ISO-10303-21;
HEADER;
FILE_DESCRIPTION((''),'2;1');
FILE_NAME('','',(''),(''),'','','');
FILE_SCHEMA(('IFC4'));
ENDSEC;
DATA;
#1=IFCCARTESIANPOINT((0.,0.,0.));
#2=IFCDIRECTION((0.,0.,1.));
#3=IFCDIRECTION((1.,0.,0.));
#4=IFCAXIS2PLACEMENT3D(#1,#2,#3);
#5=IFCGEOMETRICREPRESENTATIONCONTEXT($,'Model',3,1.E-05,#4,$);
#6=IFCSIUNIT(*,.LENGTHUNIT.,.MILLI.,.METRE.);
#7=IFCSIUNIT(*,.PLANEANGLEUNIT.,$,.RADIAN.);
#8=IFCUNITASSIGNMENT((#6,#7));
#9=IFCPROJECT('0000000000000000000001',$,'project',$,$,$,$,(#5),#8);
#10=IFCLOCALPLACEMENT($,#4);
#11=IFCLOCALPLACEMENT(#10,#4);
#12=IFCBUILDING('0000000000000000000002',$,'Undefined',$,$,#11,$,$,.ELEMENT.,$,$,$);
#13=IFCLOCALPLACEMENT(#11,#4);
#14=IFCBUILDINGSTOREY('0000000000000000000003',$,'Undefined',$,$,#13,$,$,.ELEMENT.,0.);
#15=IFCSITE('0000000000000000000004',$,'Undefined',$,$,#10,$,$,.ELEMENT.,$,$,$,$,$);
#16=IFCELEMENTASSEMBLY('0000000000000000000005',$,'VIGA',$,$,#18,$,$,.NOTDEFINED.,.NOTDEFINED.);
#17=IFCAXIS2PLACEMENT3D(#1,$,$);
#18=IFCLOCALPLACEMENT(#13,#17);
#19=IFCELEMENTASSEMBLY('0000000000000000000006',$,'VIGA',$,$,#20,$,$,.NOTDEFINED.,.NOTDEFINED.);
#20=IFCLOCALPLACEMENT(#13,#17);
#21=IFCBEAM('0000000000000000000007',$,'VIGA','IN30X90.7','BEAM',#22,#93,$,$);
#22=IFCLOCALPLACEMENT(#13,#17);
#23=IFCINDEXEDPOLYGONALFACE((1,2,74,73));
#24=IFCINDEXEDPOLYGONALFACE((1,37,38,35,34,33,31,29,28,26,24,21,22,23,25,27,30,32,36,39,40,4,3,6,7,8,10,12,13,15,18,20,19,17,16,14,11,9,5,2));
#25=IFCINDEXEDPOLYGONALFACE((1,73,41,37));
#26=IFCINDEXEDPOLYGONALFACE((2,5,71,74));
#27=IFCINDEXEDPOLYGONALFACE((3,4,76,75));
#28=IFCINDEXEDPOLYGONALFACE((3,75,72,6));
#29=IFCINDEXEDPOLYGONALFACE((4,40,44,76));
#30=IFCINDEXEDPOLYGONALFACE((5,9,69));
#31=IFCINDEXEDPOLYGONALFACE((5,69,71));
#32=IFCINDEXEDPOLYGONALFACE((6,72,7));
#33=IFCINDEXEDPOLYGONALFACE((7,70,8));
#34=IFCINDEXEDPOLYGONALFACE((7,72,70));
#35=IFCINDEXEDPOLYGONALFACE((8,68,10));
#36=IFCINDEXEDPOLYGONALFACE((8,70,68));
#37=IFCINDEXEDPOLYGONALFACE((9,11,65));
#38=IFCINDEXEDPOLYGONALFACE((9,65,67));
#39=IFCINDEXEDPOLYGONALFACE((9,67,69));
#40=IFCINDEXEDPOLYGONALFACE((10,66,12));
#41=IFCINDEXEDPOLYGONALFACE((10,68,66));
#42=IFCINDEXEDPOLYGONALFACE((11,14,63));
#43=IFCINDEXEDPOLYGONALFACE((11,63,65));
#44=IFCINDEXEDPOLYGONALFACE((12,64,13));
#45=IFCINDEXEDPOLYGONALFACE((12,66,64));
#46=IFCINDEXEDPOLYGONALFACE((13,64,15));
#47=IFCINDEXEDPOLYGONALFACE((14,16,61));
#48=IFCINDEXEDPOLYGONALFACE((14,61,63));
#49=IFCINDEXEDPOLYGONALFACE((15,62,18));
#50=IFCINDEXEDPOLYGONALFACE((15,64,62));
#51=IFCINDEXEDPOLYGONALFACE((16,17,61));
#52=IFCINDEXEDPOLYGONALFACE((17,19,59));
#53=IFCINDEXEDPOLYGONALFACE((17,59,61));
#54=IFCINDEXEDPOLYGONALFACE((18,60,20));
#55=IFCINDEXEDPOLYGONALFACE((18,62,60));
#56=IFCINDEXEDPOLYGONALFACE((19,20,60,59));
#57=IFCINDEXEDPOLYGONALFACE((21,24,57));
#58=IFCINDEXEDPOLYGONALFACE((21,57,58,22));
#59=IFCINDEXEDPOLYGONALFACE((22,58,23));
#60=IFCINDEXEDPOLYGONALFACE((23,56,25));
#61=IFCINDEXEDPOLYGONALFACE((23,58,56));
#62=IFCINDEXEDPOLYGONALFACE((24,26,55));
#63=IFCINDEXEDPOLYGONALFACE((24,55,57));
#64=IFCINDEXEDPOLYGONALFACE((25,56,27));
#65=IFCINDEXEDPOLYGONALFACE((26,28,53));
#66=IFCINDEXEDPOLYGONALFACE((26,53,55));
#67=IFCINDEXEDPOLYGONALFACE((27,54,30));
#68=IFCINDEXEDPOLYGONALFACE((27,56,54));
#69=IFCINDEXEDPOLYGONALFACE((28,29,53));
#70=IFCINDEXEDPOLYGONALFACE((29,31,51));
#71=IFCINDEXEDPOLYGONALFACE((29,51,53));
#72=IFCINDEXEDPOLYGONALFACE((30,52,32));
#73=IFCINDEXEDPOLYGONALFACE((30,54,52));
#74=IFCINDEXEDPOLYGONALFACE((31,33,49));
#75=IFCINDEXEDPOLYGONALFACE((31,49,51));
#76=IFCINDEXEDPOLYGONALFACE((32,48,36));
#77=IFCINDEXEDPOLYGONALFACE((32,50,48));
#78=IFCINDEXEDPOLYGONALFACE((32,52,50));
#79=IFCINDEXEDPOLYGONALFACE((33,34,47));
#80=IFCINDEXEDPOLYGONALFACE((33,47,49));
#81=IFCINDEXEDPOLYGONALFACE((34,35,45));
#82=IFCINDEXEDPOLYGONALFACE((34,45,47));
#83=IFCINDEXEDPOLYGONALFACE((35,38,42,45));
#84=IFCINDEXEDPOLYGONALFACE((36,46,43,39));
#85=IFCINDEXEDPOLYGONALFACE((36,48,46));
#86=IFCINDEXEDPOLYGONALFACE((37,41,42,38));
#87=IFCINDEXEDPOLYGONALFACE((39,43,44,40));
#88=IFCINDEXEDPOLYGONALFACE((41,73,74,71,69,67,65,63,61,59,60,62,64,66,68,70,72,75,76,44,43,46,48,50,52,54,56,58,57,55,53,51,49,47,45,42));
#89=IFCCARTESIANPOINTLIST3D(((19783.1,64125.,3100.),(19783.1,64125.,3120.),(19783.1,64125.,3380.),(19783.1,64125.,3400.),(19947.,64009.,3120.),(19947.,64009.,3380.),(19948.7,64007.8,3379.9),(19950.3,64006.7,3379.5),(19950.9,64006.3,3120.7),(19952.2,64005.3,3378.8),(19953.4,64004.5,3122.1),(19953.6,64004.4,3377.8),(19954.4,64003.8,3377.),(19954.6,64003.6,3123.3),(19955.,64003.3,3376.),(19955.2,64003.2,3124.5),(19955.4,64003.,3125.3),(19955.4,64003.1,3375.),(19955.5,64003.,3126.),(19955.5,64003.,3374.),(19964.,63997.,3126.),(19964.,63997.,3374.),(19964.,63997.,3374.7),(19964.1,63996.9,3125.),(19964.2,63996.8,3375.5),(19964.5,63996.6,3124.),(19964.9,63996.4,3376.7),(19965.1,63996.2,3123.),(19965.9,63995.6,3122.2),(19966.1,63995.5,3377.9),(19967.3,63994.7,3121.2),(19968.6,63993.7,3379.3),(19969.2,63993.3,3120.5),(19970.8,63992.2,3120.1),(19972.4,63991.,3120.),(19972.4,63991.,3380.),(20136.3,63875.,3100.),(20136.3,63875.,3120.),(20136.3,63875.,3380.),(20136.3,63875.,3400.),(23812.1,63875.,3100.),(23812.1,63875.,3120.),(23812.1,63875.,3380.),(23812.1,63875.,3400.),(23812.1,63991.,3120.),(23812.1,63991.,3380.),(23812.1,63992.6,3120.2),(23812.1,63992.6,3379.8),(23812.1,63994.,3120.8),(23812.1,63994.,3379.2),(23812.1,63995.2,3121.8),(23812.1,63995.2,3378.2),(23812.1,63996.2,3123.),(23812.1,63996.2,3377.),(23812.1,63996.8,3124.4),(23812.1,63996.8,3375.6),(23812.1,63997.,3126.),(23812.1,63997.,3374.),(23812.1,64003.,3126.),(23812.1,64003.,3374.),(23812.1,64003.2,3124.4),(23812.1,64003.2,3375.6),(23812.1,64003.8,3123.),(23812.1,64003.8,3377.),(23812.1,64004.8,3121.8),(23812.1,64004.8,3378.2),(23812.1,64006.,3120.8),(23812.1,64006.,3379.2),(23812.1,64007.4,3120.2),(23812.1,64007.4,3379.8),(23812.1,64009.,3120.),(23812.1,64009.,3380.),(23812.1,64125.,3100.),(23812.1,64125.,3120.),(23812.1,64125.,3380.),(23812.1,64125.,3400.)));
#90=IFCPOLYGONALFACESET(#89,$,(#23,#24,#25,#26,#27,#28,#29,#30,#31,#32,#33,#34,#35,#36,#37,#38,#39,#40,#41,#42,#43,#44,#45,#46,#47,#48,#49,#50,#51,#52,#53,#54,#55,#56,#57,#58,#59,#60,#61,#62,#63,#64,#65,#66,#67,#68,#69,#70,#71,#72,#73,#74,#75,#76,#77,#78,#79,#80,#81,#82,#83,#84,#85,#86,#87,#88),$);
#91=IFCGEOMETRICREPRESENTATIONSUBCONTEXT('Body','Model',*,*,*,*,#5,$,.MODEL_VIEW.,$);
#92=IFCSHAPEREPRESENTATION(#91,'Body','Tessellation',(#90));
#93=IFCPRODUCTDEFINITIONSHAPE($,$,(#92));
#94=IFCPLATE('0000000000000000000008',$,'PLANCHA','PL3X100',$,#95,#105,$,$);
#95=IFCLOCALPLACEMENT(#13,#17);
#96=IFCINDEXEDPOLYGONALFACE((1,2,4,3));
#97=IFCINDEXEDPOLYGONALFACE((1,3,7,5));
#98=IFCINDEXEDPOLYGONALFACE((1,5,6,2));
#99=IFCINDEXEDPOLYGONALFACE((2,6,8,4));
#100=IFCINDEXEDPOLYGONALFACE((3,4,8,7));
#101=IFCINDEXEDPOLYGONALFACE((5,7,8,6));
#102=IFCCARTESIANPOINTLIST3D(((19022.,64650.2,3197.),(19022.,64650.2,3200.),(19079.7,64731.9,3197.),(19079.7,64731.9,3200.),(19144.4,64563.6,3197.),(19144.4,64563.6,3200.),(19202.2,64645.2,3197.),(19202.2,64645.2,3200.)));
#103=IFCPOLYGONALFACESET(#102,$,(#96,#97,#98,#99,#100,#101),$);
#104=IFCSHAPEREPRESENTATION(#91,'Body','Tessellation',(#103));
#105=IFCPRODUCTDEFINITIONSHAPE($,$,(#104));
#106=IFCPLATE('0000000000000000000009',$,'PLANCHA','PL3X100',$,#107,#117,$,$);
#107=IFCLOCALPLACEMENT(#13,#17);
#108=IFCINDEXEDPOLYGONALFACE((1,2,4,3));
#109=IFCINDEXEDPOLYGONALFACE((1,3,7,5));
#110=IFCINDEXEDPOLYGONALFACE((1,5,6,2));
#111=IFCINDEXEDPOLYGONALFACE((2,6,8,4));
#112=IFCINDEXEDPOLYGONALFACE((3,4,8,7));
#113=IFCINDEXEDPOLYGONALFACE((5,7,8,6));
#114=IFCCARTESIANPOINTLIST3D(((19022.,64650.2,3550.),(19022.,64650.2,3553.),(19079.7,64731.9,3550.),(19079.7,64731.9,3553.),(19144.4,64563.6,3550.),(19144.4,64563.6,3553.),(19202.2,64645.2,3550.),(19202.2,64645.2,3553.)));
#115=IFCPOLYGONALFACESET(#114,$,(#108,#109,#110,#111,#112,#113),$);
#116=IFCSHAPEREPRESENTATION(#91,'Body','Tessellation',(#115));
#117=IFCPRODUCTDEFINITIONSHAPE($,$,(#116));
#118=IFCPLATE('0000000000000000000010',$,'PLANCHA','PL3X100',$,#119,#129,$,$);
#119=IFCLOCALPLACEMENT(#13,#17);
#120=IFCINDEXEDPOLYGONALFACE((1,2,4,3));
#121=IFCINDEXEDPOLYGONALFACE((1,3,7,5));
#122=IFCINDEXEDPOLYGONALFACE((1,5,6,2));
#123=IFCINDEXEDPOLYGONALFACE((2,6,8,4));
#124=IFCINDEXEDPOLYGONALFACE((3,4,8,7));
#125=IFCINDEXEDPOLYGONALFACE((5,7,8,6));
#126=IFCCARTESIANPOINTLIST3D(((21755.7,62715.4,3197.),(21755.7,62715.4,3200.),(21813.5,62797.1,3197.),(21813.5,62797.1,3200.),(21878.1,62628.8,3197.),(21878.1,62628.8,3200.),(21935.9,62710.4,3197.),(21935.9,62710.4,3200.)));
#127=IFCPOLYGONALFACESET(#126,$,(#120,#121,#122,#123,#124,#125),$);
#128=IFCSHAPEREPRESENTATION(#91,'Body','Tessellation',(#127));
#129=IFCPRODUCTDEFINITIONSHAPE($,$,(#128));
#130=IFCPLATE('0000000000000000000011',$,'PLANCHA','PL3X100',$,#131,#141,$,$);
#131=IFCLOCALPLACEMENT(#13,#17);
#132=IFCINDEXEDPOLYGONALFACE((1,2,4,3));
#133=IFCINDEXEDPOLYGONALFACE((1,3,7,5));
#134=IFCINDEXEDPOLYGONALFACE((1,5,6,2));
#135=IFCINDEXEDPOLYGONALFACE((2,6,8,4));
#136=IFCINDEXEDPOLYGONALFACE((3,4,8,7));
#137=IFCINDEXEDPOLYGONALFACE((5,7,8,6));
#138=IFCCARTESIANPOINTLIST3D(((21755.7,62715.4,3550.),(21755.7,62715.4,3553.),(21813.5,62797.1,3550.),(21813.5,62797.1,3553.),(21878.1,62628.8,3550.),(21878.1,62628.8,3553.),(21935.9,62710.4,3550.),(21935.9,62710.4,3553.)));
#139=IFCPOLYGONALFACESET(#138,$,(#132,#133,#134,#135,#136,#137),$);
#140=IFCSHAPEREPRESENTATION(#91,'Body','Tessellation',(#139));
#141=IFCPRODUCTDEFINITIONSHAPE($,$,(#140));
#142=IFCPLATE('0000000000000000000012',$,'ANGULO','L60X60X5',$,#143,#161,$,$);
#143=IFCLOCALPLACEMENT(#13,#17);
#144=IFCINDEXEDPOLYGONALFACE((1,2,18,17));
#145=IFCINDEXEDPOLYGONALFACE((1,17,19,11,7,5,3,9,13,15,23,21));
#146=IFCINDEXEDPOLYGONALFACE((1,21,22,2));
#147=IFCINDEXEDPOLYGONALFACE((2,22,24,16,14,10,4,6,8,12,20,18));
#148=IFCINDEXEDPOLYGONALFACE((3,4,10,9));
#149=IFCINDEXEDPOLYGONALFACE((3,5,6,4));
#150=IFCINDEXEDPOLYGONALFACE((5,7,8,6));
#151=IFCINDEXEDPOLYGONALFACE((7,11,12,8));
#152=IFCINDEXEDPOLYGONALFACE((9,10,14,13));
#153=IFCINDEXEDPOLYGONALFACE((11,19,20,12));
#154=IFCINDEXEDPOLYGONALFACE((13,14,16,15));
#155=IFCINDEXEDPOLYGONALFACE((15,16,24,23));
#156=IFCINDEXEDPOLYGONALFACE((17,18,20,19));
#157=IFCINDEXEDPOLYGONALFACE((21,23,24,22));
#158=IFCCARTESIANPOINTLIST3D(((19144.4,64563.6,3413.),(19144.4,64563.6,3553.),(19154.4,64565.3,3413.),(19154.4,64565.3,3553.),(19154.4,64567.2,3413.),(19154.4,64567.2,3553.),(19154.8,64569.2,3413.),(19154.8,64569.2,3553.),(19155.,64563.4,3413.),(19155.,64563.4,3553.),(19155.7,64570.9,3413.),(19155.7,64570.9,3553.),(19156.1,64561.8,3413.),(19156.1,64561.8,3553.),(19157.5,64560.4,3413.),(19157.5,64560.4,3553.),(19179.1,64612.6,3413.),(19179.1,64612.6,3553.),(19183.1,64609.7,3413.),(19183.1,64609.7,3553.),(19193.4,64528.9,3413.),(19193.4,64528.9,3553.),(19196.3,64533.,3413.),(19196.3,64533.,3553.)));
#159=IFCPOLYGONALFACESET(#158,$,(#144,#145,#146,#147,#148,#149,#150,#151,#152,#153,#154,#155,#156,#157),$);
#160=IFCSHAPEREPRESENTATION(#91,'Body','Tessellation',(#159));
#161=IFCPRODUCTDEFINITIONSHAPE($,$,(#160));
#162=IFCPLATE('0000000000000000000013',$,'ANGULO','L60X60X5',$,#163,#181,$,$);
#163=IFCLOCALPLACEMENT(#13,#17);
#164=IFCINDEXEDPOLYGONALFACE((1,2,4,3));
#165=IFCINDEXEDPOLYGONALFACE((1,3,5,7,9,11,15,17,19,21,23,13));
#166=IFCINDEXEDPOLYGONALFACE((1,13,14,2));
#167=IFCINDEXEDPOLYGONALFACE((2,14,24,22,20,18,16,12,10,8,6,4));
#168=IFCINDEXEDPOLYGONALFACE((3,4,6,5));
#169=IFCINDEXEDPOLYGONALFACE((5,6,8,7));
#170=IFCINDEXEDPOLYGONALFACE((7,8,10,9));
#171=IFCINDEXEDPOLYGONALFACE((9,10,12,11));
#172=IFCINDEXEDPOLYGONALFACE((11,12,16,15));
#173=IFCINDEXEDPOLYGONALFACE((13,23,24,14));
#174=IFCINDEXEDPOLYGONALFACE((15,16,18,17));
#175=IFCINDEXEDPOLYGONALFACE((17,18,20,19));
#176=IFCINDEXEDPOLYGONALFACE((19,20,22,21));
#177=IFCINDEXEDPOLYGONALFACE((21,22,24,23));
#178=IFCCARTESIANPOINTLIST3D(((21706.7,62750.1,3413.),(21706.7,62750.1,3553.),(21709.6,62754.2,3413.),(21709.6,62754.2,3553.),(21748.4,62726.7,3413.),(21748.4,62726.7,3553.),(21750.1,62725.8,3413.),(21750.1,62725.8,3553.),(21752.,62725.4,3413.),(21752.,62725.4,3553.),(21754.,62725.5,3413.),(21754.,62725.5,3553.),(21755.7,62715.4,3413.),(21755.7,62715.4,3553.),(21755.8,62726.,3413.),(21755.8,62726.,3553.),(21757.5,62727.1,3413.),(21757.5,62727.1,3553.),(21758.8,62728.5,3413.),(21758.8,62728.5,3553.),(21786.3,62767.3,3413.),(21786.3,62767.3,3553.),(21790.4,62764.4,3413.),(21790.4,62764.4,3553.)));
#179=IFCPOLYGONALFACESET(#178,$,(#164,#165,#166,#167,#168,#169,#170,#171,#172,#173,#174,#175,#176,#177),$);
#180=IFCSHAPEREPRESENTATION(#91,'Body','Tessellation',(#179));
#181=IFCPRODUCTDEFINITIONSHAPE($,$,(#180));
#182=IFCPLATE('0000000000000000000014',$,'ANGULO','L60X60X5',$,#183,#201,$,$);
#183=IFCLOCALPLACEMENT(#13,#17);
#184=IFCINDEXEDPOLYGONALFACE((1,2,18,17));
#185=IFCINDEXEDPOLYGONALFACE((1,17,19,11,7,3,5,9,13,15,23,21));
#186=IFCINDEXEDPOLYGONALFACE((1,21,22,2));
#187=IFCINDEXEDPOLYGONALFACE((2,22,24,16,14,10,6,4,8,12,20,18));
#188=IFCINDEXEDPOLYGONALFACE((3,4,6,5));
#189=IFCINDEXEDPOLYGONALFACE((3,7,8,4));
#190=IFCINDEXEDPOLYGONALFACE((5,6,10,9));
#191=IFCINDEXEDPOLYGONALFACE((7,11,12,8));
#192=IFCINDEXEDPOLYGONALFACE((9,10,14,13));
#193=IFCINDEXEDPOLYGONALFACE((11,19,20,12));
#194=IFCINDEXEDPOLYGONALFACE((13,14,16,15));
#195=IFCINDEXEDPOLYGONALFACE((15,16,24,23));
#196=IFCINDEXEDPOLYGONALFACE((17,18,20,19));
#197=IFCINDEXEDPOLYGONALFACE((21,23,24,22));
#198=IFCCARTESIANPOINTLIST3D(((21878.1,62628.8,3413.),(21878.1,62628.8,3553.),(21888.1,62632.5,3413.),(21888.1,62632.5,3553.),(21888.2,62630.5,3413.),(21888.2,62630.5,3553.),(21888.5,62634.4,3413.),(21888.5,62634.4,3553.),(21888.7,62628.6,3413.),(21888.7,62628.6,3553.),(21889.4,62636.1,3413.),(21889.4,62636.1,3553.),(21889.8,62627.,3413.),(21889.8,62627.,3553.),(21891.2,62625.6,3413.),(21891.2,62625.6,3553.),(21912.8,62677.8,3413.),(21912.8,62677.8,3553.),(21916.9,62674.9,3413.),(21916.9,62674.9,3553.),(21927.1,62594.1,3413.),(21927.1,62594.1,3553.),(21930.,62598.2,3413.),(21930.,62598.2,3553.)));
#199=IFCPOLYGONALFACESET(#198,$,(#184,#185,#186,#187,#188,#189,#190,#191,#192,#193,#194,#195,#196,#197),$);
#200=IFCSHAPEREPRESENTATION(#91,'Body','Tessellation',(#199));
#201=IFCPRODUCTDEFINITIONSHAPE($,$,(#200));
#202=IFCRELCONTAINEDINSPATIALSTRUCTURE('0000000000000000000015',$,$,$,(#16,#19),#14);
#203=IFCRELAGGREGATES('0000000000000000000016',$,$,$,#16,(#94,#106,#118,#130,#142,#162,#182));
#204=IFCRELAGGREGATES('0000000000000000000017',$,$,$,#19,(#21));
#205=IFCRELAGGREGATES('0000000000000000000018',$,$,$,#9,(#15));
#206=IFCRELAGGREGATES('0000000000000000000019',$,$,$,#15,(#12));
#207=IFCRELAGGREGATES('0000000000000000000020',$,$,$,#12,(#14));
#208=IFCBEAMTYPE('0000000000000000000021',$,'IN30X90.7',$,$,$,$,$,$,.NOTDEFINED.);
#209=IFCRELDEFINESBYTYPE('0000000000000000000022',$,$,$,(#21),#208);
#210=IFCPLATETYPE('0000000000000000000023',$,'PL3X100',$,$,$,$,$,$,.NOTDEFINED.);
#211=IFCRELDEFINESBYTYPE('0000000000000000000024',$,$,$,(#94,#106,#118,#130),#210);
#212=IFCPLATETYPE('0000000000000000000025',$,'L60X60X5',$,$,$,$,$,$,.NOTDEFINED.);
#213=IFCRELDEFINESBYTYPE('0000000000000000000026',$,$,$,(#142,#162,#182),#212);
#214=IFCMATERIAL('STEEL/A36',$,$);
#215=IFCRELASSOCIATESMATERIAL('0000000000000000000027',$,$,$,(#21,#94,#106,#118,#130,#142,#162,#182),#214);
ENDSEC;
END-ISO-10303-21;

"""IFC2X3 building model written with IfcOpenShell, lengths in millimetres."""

from ifc_helpers import new_model, si_unit, frame, origin_with_axes, origin_2d_with_axis, place, context, subcontext, project, spatial, polyline, i_section, l_section, outline, extrude, clip, halfspace, material, type_object, element, aggregate, save


model = new_model("IFC2X3")

# Units and contexts
model_context = context("Model", 3, precision=1e-05, world=origin_with_axes())
body_context = subcontext(model_context, "Body", "Model", "MODEL_VIEW")
ifc_project = project(units=[si_unit("LENGTHUNIT", "METRE", prefix="MILLI"), si_unit("PLANEANGLEUNIT", "RADIAN")], contexts=[model_context])

# Site, building, storey
site_placement = place(None, origin_with_axes())
site = spatial("IfcSite", under=ifc_project, at=site_placement, Name="Undefined", CompositionType="ELEMENT")
building_placement = place(site_placement, origin_with_axes())
building = spatial("IfcBuilding", under=site, at=building_placement, Name="Undefined", CompositionType="ELEMENT")
storey_placement = place(building_placement, origin_with_axes())
storey = spatial("IfcBuildingStorey", under=building, at=storey_placement, Name="Undefined", CompositionType="ELEMENT", Elevation=0.0)

# Element assembly
assembly_1_placement = place(storey_placement, origin_with_axes())
assembly_1 = element("IfcElementAssembly", 1, at=assembly_1_placement, inside=storey, Name="VIGA", AssemblyPlace="NOTDEFINED", PredefinedType="NOTDEFINED")
ifc_material_1 = material(Name="STEEL/A36")

# Element assembly, beam
assembly_2_placement = place(storey_placement, origin_with_axes())
assembly_2 = element("IfcElementAssembly", 2, at=assembly_2_placement, inside=storey, Name="VIGA", AssemblyPlace="NOTDEFINED", PredefinedType="NOTDEFINED")
beam_type_1 = type_object("IfcBeamType", Name="IN30X90.7", PredefinedType="NOTDEFINED")
beam_1_placement = place(assembly_2_placement, frame((19924.1, 64000.0, 3250.0), z_axis=(0.0, 0.0, 1.0), x_axis=(1.0, 0.0, 0.0)))
beam_1 = element("IfcBeam", 3, at=beam_1_placement, type_object=beam_type_1, material=ifc_material_1, Name="VIGA", Description="IN30X90.7", ObjectType="BEAM", context=body_context, shape_type="Clipping", body=[
    clip(extrude(i_section(OverallWidth=250.0, OverallDepth=300.0, WebThickness=6.0, FlangeThickness=20.0, FilletRadius=6.0, at=origin_2d_with_axis()), frame((3888.0, 0.0, 0.0), z_axis=(-1.0, 0.0, 0.0), x_axis=(0.0, -1.0, 0.0)), (0.0, 0.0, 1.0), 4030.8), halfspace(frame((24.1, 8.2, 250.0), z_axis=(-0.577701, -0.816249, 0.0), x_axis=(0.816249, -0.577701, 0.0)), False)),
])

# Plates
plate_type_1 = type_object("IfcPlateType", Name="PL3X100", PredefinedType="NOTDEFINED")
plate_1_placement = place(assembly_1_placement, frame((19144.4, 64563.6, 3198.5), z_axis=(0.0, 0.0, 1.0), x_axis=(0.577701, 0.816249, 0.0)))
plate_1 = element("IfcPlate", 4, at=plate_1_placement, type_object=plate_type_1, material=ifc_material_1, Name="PLANCHA", Description="PL3X100", context=body_context, shape_type="SweptSolid", body=[
    extrude(outline(polyline([(0.0, 0.0), (100.0, 0.0), (100.0, 150.0), (0.0, 150.0), (0.0, 0.0)])), frame((0.0, 0.0, -1.5), z_axis=(0.0, 0.0, 1.0), x_axis=(1.0, 0.0, 0.0)), (0.0, 0.0, 1.0), 3.0),
])
plate_2_placement = place(assembly_1_placement, frame((19202.2, 64645.2, 3551.5), z_axis=(0.0, 0.0, -1.0), x_axis=(-0.577701, -0.816249, 0.0)))
plate_2 = element("IfcPlate", 5, at=plate_2_placement, type_object=plate_type_1, material=ifc_material_1, Name="PLANCHA", Description="PL3X100", context=body_context, shape_type="SweptSolid", body=[
    extrude(outline(polyline([(0.0, 0.0), (100.0, 0.0), (100.0, 150.0), (0.0, 150.0), (0.0, 0.0)])), frame((0.0, 0.0, -1.5), z_axis=(0.0, 0.0, 1.0), x_axis=(1.0, 0.0, 0.0)), (0.0, 0.0, 1.0), 3.0),
])
plate_3_placement = place(assembly_1_placement, frame((21878.1, 62628.8, 3198.5), z_axis=(0.0, 0.0, 1.0), x_axis=(0.577701, 0.816249, 0.0)))
plate_3 = element("IfcPlate", 6, at=plate_3_placement, type_object=plate_type_1, material=ifc_material_1, Name="PLANCHA", Description="PL3X100", context=body_context, shape_type="SweptSolid", body=[
    extrude(outline(polyline([(0.0, 0.0), (100.0, 0.0), (100.0, 150.0), (0.0, 150.0), (0.0, 0.0)])), frame((0.0, 0.0, -1.5), z_axis=(0.0, 0.0, 1.0), x_axis=(1.0, 0.0, 0.0)), (0.0, 0.0, 1.0), 3.0),
])
plate_4_placement = place(assembly_1_placement, frame((21935.9, 62710.4, 3551.5), z_axis=(0.0, 0.0, -1.0), x_axis=(-0.577701, -0.816249, 0.0)))
plate_4 = element("IfcPlate", 7, at=plate_4_placement, type_object=plate_type_1, material=ifc_material_1, Name="PLANCHA", Description="PL3X100", context=body_context, shape_type="SweptSolid", body=[
    extrude(outline(polyline([(0.0, 0.0), (100.0, 0.0), (100.0, 150.0), (0.0, 150.0), (0.0, 0.0)])), frame((0.0, 0.0, -1.5), z_axis=(0.0, 0.0, 1.0), x_axis=(1.0, 0.0, 0.0)), (0.0, 0.0, 1.0), 3.0),
])
plate_type_2 = type_object("IfcPlateType", Name="L60X60X5", PredefinedType="NOTDEFINED")
plate_5_placement = place(assembly_1_placement, frame((19186.2, 64570.7, 3553.0), z_axis=(0.577701, 0.816249, 0.0), x_axis=(0.0, 0.0, -1.0)))
plate_5 = element("IfcPlate", 8, at=plate_5_placement, type_object=plate_type_2, material=ifc_material_1, Name="ANGULO", Description="L60X60X5", context=body_context, shape_type="SweptSolid", body=[
    extrude(l_section(Depth=60.0, Width=60.0, Thickness=5.0, FilletRadius=7.5, at=origin_2d_with_axis()), frame((140.0, 0.0, 0.0), z_axis=(-1.0, 0.0, 0.0), x_axis=(0.0, -1.0, 0.0)), (0.0, 0.0, 1.0), 140.0),
])
plate_6_placement = place(assembly_1_placement, frame((21748.5, 62757.3, 3413.0), z_axis=(0.577701, 0.816249, 0.0), x_axis=(0.0, 0.0, 1.0)))
plate_6 = element("IfcPlate", 9, at=plate_6_placement, type_object=plate_type_2, material=ifc_material_1, Name="ANGULO", Description="L60X60X5", context=body_context, shape_type="SweptSolid", body=[
    extrude(l_section(Depth=60.0, Width=60.0, Thickness=5.0, FilletRadius=7.5, at=origin_2d_with_axis()), frame((140.0, 0.0, 0.0), z_axis=(-1.0, 0.0, 0.0), x_axis=(0.0, -1.0, 0.0)), (0.0, 0.0, 1.0), 140.0),
])
plate_7_placement = place(assembly_1_placement, frame((21919.9, 62635.9, 3553.0), z_axis=(0.577701, 0.816249, 0.0), x_axis=(0.0, 0.0, -1.0)))
plate_7 = element("IfcPlate", 10, at=plate_7_placement, type_object=plate_type_2, material=ifc_material_1, Name="ANGULO", Description="L60X60X5", context=body_context, shape_type="SweptSolid", body=[
    extrude(l_section(Depth=60.0, Width=60.0, Thickness=5.0, FilletRadius=7.5, at=origin_2d_with_axis()), frame((140.0, 0.0, 0.0), z_axis=(-1.0, 0.0, 0.0), x_axis=(0.0, -1.0, 0.0)), (0.0, 0.0, 1.0), 140.0),
])
aggregate(assembly_1, [plate_1, plate_2, plate_3, plate_4, plate_5, plate_6, plate_7])

aggregate(assembly_2, [beam_1])

save(model, "model.ifc")
